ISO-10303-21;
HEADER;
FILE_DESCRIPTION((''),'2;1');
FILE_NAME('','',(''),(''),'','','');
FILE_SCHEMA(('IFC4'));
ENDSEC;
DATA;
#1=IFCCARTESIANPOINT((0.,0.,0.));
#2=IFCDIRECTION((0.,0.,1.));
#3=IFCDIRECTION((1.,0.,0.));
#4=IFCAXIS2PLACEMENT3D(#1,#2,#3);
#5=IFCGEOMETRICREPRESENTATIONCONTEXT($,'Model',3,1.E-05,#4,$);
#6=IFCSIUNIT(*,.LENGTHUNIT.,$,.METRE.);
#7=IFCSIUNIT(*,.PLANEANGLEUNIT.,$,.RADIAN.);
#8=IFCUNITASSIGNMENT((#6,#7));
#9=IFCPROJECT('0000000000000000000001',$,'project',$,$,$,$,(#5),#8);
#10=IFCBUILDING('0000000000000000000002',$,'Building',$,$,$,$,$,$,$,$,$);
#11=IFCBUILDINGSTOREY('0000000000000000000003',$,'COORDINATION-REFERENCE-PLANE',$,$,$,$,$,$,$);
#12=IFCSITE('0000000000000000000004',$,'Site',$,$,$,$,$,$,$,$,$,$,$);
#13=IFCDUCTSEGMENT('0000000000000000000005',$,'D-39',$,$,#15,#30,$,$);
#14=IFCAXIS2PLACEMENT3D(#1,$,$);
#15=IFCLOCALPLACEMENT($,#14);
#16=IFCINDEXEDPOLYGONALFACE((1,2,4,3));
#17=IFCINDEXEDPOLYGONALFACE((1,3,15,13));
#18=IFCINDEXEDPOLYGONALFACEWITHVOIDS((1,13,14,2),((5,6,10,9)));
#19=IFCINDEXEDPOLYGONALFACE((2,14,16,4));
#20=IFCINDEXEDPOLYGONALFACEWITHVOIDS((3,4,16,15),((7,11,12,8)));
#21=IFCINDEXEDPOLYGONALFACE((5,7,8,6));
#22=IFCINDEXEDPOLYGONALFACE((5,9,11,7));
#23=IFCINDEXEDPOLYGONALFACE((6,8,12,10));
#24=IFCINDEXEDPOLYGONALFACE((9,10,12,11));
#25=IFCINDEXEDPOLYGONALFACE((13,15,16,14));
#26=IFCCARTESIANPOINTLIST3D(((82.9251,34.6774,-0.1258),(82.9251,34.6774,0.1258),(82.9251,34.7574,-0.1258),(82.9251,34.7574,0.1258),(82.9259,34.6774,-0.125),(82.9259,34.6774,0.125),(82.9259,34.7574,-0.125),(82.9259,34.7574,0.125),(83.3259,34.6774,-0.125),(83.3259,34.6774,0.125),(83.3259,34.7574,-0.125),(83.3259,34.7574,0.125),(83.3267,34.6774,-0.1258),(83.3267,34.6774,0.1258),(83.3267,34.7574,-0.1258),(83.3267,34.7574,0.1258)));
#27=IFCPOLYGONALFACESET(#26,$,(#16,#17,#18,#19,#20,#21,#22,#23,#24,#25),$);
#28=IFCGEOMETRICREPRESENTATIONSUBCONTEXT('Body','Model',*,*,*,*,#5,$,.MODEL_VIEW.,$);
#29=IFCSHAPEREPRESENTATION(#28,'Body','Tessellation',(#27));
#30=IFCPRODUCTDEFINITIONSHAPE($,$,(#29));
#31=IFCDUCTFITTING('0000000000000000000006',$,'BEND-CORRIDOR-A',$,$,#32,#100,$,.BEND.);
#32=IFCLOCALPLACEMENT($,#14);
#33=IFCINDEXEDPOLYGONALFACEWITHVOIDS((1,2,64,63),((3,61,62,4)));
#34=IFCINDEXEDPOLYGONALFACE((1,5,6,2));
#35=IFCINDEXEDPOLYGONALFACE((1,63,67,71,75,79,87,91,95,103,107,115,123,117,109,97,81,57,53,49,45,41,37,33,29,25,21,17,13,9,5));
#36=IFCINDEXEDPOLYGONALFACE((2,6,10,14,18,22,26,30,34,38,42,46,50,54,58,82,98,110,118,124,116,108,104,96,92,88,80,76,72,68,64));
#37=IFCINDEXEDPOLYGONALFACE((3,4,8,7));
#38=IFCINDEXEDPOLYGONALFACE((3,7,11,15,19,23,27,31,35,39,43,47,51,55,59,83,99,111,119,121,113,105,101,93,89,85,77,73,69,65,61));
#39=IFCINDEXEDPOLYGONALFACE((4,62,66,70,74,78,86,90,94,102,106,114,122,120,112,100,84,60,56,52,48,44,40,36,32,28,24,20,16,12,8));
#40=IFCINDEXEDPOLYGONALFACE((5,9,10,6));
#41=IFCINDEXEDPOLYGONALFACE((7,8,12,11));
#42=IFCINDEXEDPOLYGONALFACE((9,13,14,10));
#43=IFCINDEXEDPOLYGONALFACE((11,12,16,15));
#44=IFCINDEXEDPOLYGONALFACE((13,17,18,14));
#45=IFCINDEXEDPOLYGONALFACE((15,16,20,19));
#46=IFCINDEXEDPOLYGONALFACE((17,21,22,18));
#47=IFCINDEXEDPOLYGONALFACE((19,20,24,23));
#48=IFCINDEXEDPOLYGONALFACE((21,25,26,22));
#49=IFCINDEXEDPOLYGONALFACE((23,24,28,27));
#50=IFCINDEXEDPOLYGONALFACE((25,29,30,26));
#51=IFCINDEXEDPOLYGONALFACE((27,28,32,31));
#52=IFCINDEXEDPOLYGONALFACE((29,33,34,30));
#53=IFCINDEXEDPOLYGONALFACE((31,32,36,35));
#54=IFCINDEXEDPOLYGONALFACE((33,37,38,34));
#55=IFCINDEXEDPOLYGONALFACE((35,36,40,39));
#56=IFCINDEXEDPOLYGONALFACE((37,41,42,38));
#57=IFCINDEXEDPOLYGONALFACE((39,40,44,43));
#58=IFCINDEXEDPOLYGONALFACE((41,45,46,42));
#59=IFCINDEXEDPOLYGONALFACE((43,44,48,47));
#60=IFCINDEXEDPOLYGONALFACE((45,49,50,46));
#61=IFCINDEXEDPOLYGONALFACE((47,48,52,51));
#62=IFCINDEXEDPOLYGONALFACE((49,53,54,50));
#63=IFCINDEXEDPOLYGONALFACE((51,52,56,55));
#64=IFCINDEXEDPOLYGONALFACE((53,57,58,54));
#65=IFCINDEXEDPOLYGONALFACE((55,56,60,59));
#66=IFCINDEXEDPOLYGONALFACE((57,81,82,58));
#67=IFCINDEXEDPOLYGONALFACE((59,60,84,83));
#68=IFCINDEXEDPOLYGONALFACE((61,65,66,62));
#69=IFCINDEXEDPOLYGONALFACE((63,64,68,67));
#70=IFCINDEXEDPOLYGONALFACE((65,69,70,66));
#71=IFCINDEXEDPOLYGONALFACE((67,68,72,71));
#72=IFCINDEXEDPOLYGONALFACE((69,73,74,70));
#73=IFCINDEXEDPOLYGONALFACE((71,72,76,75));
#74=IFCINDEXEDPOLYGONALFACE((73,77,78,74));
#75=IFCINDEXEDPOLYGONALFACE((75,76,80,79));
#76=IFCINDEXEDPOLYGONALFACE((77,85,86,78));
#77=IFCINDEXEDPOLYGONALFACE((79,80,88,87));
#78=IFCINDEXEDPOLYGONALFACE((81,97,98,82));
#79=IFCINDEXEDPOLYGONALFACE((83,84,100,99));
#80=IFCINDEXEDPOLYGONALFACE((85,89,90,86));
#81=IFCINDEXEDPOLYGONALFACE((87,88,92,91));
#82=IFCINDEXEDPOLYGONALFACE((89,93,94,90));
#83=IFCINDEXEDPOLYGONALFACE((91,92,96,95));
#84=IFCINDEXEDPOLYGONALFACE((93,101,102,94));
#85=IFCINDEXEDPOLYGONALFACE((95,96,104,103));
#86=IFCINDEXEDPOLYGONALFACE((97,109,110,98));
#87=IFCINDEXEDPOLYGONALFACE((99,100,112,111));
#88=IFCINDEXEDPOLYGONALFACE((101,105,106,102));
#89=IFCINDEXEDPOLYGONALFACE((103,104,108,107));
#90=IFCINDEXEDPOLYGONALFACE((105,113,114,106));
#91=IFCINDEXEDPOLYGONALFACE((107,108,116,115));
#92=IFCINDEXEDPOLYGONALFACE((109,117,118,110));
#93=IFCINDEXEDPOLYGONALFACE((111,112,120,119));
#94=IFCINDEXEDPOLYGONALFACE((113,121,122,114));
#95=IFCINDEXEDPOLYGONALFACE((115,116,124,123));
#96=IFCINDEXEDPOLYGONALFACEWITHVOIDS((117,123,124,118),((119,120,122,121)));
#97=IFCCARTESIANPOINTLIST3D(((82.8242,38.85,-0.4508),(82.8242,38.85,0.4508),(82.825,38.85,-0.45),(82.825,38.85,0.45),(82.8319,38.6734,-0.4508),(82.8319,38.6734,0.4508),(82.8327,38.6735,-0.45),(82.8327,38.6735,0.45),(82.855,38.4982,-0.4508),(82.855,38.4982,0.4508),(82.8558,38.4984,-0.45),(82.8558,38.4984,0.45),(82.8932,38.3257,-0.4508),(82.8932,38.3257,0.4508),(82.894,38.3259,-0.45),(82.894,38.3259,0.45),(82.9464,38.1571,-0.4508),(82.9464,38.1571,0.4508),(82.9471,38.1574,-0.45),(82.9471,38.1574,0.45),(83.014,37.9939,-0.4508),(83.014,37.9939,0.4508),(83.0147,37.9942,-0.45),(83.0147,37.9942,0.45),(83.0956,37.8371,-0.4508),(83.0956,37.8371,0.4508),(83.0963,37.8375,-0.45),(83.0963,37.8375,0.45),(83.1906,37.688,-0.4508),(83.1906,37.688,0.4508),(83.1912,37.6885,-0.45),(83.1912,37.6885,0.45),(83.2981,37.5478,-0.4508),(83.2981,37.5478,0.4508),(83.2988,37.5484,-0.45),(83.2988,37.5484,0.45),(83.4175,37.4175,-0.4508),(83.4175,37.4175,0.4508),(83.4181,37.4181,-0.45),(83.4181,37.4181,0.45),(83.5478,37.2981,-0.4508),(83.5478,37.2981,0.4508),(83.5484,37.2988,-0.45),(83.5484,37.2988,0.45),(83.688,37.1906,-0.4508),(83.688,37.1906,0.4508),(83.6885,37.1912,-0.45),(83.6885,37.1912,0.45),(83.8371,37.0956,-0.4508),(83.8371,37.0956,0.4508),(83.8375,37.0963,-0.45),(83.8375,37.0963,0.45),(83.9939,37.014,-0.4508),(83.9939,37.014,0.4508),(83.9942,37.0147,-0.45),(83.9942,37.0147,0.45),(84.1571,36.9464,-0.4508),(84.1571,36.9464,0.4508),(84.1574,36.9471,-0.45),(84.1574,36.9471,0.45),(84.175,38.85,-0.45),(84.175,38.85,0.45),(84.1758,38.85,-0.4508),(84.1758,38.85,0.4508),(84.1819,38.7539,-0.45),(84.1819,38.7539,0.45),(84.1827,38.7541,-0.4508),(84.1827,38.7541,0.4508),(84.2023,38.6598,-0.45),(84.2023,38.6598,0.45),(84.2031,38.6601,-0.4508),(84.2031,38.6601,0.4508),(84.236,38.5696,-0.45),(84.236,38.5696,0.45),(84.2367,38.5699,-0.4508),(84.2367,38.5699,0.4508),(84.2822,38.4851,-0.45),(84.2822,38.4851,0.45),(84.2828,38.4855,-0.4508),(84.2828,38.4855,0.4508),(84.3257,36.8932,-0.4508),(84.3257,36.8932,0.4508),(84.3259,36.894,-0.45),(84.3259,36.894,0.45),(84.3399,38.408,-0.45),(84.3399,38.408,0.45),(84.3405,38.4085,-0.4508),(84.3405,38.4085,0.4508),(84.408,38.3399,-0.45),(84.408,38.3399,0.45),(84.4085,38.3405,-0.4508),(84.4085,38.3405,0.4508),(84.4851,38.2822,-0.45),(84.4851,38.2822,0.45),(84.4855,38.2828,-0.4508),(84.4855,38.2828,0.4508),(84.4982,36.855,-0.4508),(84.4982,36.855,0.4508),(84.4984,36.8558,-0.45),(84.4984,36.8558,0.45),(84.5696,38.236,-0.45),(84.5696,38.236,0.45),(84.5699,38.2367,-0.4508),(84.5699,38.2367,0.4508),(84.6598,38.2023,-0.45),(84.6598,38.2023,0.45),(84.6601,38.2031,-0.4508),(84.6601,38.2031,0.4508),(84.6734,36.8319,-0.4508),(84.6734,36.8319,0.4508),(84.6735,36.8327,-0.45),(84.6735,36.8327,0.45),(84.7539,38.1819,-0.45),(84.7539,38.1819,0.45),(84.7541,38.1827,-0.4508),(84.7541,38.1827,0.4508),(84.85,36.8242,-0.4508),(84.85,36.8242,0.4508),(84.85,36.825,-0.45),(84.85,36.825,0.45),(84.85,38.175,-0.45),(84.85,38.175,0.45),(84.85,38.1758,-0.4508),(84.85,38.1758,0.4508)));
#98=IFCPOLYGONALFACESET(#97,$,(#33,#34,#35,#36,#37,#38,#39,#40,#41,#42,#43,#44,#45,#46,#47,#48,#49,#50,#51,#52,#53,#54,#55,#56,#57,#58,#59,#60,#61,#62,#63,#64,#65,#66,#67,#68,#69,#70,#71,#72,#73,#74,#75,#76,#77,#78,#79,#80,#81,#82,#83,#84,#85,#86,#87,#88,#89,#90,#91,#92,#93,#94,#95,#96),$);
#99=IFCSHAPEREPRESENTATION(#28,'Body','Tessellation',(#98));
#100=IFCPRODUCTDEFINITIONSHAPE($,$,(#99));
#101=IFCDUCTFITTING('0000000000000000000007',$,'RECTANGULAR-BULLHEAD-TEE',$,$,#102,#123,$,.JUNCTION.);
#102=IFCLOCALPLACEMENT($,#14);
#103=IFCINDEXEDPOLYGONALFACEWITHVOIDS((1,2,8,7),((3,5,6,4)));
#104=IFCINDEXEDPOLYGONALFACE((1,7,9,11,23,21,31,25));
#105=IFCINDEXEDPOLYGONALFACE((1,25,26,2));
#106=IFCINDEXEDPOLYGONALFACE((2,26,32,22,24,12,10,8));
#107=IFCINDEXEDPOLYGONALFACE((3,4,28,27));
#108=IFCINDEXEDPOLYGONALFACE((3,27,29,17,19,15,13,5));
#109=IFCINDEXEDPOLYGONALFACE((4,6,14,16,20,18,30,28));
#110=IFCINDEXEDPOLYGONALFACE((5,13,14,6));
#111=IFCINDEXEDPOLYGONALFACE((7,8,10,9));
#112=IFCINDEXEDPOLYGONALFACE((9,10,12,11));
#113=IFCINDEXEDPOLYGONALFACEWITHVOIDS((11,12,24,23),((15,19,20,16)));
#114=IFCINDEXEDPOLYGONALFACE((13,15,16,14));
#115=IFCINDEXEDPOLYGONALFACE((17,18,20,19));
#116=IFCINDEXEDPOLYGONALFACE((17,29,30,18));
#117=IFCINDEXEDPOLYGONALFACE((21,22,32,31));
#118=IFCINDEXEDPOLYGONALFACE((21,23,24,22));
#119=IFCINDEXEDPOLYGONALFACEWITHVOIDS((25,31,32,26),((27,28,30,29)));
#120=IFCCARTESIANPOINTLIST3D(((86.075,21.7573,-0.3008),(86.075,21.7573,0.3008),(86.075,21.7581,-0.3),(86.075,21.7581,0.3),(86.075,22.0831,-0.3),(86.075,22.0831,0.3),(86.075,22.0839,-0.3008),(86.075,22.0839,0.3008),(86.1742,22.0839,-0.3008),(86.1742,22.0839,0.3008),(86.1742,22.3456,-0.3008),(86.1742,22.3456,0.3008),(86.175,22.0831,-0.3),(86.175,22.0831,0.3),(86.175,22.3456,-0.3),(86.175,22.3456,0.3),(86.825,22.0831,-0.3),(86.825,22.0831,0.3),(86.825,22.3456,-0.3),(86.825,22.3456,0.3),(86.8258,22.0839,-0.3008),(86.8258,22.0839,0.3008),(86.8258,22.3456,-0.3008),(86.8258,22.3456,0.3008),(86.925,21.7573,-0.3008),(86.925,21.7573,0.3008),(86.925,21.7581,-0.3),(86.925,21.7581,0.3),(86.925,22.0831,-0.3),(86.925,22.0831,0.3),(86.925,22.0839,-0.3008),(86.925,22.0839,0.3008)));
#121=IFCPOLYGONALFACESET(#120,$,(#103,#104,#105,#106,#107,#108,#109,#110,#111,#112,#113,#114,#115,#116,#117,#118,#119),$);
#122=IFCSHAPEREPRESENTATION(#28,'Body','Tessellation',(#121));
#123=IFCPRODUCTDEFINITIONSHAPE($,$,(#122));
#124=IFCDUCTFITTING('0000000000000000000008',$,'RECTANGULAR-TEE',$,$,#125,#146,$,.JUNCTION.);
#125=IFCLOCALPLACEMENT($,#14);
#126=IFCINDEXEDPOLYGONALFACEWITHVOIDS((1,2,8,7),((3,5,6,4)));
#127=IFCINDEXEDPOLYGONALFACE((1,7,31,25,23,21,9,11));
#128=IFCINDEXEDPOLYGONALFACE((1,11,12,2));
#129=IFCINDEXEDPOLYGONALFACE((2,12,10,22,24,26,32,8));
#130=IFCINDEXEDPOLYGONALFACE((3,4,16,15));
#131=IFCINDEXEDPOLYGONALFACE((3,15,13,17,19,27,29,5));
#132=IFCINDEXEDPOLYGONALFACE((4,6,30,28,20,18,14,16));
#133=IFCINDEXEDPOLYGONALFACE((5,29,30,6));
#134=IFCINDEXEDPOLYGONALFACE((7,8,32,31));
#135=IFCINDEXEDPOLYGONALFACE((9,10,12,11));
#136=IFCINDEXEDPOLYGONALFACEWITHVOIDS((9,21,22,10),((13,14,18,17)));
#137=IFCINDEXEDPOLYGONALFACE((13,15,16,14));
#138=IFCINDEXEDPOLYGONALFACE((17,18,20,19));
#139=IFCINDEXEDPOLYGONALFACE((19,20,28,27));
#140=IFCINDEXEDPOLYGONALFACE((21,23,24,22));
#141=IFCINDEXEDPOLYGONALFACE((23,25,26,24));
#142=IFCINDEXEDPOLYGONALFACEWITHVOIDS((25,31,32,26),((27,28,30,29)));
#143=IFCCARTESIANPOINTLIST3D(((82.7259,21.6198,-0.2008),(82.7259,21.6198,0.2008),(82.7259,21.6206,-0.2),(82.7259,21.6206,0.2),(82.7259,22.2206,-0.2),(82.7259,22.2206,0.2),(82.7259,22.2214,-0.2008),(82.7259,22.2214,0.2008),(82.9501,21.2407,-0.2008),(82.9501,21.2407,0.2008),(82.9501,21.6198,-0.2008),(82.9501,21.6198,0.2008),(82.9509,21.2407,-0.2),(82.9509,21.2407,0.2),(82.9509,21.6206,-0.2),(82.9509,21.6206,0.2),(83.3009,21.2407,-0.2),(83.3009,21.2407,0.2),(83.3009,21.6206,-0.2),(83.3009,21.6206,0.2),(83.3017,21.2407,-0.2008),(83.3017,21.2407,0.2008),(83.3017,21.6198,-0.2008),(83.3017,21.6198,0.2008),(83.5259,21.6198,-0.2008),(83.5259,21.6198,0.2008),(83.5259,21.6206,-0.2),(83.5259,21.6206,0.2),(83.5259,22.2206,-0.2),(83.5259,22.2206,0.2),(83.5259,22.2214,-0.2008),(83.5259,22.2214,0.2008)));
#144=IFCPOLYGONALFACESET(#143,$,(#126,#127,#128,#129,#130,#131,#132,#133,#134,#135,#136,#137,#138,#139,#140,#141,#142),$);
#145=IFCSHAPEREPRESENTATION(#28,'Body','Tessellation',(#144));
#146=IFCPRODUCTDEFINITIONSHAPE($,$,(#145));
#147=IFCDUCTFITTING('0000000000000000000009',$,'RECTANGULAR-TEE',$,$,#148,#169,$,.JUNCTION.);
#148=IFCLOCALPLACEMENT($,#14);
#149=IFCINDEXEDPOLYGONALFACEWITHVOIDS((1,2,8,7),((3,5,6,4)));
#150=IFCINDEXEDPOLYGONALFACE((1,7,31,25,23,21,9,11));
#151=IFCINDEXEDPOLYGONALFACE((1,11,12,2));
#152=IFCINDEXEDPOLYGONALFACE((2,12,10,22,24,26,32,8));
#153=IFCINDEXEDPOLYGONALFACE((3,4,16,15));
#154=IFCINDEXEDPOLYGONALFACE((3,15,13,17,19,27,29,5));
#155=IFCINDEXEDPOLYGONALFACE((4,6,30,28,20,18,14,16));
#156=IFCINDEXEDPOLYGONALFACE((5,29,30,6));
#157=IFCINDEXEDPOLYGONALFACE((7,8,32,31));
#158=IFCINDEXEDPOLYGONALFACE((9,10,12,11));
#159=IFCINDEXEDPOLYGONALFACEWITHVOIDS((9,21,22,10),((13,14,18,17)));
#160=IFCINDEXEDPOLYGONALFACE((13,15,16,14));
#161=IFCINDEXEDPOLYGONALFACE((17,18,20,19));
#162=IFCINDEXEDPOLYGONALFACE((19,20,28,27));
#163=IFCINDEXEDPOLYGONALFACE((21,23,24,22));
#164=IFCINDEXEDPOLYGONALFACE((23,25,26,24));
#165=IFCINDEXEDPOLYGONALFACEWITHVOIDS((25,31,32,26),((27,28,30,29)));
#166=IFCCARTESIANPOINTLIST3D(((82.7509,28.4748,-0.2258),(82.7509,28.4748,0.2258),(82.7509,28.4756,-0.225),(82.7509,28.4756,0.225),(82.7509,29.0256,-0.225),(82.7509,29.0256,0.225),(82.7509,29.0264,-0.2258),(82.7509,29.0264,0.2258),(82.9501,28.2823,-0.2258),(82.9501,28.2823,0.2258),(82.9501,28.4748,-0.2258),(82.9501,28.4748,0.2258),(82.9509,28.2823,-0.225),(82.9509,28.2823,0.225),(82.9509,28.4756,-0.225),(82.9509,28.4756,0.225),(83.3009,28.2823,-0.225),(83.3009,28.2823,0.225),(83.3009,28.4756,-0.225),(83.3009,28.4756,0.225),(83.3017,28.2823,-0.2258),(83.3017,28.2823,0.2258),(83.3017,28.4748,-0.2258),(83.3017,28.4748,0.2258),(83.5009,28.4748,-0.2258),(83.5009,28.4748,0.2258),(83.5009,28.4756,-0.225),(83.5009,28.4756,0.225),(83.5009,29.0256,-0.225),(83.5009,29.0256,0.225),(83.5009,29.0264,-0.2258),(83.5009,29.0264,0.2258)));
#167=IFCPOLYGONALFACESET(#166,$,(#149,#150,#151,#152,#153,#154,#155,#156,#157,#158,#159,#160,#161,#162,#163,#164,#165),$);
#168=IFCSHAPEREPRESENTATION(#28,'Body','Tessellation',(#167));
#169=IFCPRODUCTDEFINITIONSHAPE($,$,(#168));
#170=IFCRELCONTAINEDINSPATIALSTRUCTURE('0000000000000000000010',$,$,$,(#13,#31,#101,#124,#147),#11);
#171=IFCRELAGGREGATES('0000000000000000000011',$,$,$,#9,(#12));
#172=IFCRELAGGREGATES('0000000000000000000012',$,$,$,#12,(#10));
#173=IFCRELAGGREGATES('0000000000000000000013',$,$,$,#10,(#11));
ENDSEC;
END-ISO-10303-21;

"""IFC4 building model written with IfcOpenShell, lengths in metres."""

from ifc_helpers import new_model, entity, si_unit, frame, origin, origin_with_axes, place, context, subcontext, project, spatial, rectangle, hollow_rectangle, extrude, boolean, element, save


model = new_model("IFC4")

# Units and contexts
model_context = context("Model", 3, precision=1e-05, world=origin_with_axes())
body_context_1 = subcontext(model_context, "Body", "Model", "MODEL_VIEW")
ifc_project = project(units=[si_unit("LENGTHUNIT", "METRE"), si_unit("PLANEANGLEUNIT", "RADIAN")], contexts=[model_context])

# Site, building, storey
site = spatial("IfcSite", under=ifc_project, Name="Site")
building = spatial("IfcBuilding", under=site, Name="Building")
storey = spatial("IfcBuildingStorey", under=building, Name="COORDINATION-REFERENCE-PLANE")

# Duct segment
duct_segment_1_placement = place(None, frame((83.1259, 34.6774, 0.0), z_axis=(0.0, 1.0, 0.0), x_axis=(1.0, 0.0, 0.0)))
element("IfcDuctSegment", 1, at=duct_segment_1_placement, inside=storey, Name="D-39", context=body_context_1, shape_type="SweptSolid", body=[
    extrude(hollow_rectangle(XDim=0.4016, YDim=0.2516, WallThickness=0.0008), origin(), (0.0, 0.0, 1.0), 0.08),
])

# Duct fittings
duct_fitting_1_placement = place(None, frame((84.85, 38.85, 0.0), z_axis=(0.0, 0.0, 1.0), x_axis=(-1.0, 0.0, 0.0)))
cartesian_point_1 = entity("IfcCartesianPoint", [0.0, 0.0, 0.0])
element("IfcDuctFitting", 2, at=duct_fitting_1_placement, inside=storey, Name="BEND-CORRIDOR-A", PredefinedType="BEND", context=body_context_1, shape_type="SweptSolid", body=[
    entity("IfcRevolvedAreaSolid", entity("IfcRectangleHollowProfileDef", "AREA", None, entity("IfcAxis2Placement2D", entity("IfcCartesianPoint", [1.35, 0.0])), 1.3516, 0.9016, 0.0008), entity("IfcAxis2Placement3D", cartesian_point_1, entity("IfcDirection", [0.0, -1.0, 0.0]), entity("IfcDirection", [1.0, 0.0, 0.0])), entity("IfcAxis1Placement", cartesian_point_1, entity("IfcDirection", [0.0, 1.0, 0.0])), 1.570796),
])
duct_fitting_2_placement = place(None, frame((86.5, 21.9206, 0.0), z_axis=(1.0, 0.0, 0.0), x_axis=(0.0, 1.0, 0.0)))
solid_1 = boolean("UNION", extrude(rectangle(XDim=0.325, YDim=0.6), frame((0.0, 0.0, -0.425), z_axis=(0.0, 0.0, 1.0), x_axis=(1.0, 0.0, 0.0)), (0.0, 0.0, 1.0), 0.85), extrude(rectangle(XDim=0.65, YDim=0.6), frame((0.0, 0.0, 0.0), z_axis=(1.0, 0.0, 0.0), x_axis=(0.0, 0.0, -1.0)), (0.0, 0.0, 1.0), 0.425))
element("IfcDuctFitting", 3, at=duct_fitting_2_placement, inside=storey, Name="RECTANGULAR-BULLHEAD-TEE", PredefinedType="JUNCTION", context=body_context_1, shape_type="CSG", body=[
    boolean("DIFFERENCE", boolean("UNION", extrude(rectangle(XDim=0.3266, YDim=0.6016), frame((0.0, 0.0, -0.425), z_axis=(0.0, 0.0, 1.0), x_axis=(1.0, 0.0, 0.0)), (0.0, 0.0, 1.0), 0.85), extrude(rectangle(XDim=0.6516, YDim=0.6016), frame((0.0, 0.0, 0.0), z_axis=(1.0, 0.0, 0.0), x_axis=(0.0, 0.0, -1.0)), (0.0, 0.0, 1.0), 0.425)), solid_1),
])
duct_fitting_3_placement = place(None, frame((83.1259, 21.9206, 0.0), z_axis=(-1.0, 0.0, 0.0), x_axis=(0.0, -1.0, 0.0)))
solid_2 = boolean("UNION", extrude(rectangle(XDim=0.6, YDim=0.4), frame((0.0, 0.0, -0.4), z_axis=(0.0, 0.0, 1.0), x_axis=(1.0, 0.0, 0.0)), (0.0, 0.0, 1.0), 0.8), extrude(rectangle(XDim=0.35, YDim=0.4), frame((0.0, 0.0, 0.0), z_axis=(1.0, 0.0, 0.0), x_axis=(0.0, 0.0, -1.0)), (0.0, 0.0, 1.0), 0.6799))
element("IfcDuctFitting", 4, at=duct_fitting_3_placement, inside=storey, Name="RECTANGULAR-TEE", PredefinedType="JUNCTION", context=body_context_1, shape_type="CSG", body=[
    boolean("DIFFERENCE", boolean("UNION", extrude(rectangle(XDim=0.6016, YDim=0.4016), frame((0.0, 0.0, -0.4), z_axis=(0.0, 0.0, 1.0), x_axis=(1.0, 0.0, 0.0)), (0.0, 0.0, 1.0), 0.8), extrude(rectangle(XDim=0.3516, YDim=0.4016), frame((0.0, 0.0, 0.0), z_axis=(1.0, 0.0, 0.0), x_axis=(0.0, 0.0, -1.0)), (0.0, 0.0, 1.0), 0.6799)), solid_2),
])
duct_fitting_4_placement = place(None, frame((83.1259, 28.7506, 0.0), z_axis=(-1.0, 0.0, 0.0), x_axis=(0.0, -1.0, 0.0)))
solid_3 = boolean("UNION", extrude(rectangle(XDim=0.55, YDim=0.45), frame((0.0, 0.0, -0.375), z_axis=(0.0, 0.0, 1.0), x_axis=(1.0, 0.0, 0.0)), (0.0, 0.0, 1.0), 0.75), extrude(rectangle(XDim=0.35, YDim=0.45), frame((0.0, 0.0, 0.0), z_axis=(1.0, 0.0, 0.0), x_axis=(0.0, 0.0, -1.0)), (0.0, 0.0, 1.0), 0.4683))
element("IfcDuctFitting", 5, at=duct_fitting_4_placement, inside=storey, Name="RECTANGULAR-TEE", PredefinedType="JUNCTION", context=body_context_1, shape_type="CSG", body=[
    boolean("DIFFERENCE", boolean("UNION", extrude(rectangle(XDim=0.5516, YDim=0.4516), frame((0.0, 0.0, -0.375), z_axis=(0.0, 0.0, 1.0), x_axis=(1.0, 0.0, 0.0)), (0.0, 0.0, 1.0), 0.75), extrude(rectangle(XDim=0.3516, YDim=0.4516), frame((0.0, 0.0, 0.0), z_axis=(1.0, 0.0, 0.0), x_axis=(0.0, 0.0, -1.0)), (0.0, 0.0, 1.0), 0.4683)), solid_3),
])

save(model, "model.ifc")
